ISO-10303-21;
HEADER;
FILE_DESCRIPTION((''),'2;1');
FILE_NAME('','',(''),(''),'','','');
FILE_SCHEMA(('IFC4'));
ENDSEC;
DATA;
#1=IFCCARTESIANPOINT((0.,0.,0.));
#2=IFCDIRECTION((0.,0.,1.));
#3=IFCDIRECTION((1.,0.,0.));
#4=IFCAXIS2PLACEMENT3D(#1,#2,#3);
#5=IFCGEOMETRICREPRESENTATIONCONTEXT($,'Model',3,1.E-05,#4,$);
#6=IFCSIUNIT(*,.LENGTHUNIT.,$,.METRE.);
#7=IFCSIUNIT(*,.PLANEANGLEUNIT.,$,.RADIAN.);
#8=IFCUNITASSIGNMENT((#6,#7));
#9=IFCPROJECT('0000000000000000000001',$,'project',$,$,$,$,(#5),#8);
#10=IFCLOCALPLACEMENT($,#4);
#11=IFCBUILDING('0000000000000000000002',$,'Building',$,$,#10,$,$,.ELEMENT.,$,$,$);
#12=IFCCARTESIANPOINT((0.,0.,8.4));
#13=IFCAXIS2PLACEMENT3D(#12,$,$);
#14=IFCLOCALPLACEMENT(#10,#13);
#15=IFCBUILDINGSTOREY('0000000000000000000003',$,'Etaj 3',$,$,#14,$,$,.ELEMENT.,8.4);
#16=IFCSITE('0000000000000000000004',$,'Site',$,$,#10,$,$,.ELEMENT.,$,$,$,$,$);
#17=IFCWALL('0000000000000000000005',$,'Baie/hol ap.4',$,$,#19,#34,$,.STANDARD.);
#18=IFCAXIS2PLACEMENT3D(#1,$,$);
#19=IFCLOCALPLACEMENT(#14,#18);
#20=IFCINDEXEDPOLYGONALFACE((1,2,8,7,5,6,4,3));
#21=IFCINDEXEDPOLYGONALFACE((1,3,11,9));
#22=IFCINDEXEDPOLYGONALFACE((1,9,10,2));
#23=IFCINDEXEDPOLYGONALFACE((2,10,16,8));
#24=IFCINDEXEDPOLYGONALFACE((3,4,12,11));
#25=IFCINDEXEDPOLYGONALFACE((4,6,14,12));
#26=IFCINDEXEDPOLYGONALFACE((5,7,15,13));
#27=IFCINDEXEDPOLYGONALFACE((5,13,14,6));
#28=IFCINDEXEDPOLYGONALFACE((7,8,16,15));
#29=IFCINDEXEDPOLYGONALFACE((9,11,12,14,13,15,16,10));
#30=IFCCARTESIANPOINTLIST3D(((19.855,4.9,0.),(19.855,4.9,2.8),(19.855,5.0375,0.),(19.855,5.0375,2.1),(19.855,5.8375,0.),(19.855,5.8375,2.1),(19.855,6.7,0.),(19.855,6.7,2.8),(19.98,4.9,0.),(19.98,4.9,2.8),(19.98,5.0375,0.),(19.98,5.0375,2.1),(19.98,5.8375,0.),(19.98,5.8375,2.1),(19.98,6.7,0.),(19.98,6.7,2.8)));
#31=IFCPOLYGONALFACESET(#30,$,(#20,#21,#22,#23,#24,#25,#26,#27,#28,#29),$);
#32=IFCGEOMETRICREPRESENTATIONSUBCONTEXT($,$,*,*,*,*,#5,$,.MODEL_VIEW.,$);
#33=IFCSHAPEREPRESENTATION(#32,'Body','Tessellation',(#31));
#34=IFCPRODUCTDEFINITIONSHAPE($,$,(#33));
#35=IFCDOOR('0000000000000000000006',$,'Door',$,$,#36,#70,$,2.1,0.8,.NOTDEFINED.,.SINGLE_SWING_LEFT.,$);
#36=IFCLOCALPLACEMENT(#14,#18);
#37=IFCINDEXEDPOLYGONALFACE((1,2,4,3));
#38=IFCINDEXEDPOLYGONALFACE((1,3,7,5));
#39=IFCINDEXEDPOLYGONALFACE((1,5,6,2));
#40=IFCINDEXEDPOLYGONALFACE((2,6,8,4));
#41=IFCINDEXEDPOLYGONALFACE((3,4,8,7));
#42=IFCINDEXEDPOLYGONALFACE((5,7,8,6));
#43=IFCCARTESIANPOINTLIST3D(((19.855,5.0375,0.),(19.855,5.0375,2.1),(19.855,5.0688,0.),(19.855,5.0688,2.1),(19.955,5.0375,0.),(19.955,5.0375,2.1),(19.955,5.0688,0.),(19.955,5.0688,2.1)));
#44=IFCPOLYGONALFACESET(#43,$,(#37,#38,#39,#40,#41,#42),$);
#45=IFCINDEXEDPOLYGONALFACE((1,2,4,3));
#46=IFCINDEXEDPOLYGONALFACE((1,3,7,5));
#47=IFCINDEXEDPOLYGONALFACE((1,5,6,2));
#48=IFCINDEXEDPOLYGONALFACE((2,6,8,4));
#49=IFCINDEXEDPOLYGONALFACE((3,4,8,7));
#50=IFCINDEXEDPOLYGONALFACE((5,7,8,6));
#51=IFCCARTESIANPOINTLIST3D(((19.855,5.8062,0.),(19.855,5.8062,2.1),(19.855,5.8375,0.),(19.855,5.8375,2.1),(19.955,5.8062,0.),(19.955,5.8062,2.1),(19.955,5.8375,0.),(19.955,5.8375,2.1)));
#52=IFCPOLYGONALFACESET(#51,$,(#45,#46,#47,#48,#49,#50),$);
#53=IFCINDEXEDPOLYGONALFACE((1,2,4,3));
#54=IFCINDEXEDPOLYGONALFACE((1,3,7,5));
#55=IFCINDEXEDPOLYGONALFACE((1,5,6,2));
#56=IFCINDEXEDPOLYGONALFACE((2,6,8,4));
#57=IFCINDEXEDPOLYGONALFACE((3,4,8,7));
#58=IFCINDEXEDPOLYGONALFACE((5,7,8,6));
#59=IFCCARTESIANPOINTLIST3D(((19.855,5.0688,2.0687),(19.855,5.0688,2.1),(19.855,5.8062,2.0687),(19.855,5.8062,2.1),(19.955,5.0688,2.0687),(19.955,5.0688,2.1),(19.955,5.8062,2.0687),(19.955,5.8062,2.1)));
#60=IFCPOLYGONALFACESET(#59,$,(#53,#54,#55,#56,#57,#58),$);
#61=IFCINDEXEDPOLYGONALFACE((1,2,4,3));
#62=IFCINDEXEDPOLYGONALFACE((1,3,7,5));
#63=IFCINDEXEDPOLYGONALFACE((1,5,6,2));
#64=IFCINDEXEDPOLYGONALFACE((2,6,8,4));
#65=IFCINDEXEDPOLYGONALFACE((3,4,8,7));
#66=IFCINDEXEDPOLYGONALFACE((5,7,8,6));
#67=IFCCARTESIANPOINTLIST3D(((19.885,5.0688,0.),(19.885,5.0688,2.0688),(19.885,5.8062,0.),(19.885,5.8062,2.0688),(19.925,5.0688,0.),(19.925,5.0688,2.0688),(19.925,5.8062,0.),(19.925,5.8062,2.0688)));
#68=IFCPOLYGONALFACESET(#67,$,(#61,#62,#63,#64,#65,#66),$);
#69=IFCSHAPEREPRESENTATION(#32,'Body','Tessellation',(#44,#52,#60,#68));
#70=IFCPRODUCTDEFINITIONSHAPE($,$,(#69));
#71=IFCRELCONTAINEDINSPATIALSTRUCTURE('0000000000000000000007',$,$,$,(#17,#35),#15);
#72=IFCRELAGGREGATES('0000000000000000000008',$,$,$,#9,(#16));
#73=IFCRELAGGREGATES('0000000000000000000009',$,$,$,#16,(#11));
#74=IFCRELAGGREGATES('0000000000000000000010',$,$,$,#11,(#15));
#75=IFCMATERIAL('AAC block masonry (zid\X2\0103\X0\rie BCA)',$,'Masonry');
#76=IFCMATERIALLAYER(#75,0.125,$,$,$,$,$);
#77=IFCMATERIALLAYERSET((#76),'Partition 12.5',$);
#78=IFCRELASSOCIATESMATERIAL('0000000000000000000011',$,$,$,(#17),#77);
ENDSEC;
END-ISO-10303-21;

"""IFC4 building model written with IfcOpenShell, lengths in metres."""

from ifc_helpers import new_model, si_unit, frame, frame_2d, origin, origin_with_axes, origin_2d, place, context, subcontext, project, spatial, rectangle, extrude, material, layer, layer_set, layer_usage, element, fill, save


model = new_model("IFC4")

# Units and contexts
model_context = context("Model", 3, precision=1e-05, world=origin_with_axes())
sub_context = subcontext(model_context, None, None, "MODEL_VIEW")
ifc_project = project(units=[si_unit("LENGTHUNIT", "METRE"), si_unit("PLANEANGLEUNIT", "RADIAN")], contexts=[model_context])

# Site, building, storey
placement = place(None, origin_with_axes())
site = spatial("IfcSite", under=ifc_project, at=placement, Name="Site", CompositionType="ELEMENT")
building = spatial("IfcBuilding", under=site, at=placement, Name="Building", CompositionType="ELEMENT")
storey_placement = place(placement, frame((0.0, 0.0, 8.4)))
storey = spatial("IfcBuildingStorey", under=building, at=storey_placement, Name="Etaj 3", CompositionType="ELEMENT", Elevation=8.4)

# Shared definitions
ifc_material_1 = material(Name="AAC block masonry (zidărie BCA)", Category="Masonry")
ifc_layer_1 = layer(ifc_material_1, 0.125)
ifc_layer_set_1 = layer_set([ifc_layer_1], Name="Partition 12.5")
ifc_layer_usage_1 = layer_usage(ifc_layer_set_1, "AXIS2", "POSITIVE", -0.0625)

# Wall, opening, door
wall_1_placement = place(storey_placement, frame((19.9175, 4.9, 0.0), x_axis=(0.0, 1.0, 0.0)))
wall_1 = element("IfcWall", 1, at=wall_1_placement, inside=storey, material=ifc_layer_usage_1, Name="Baie/hol ap.4", PredefinedType="STANDARD", context=sub_context, shape_type="SweptSolid", body=[
    extrude(rectangle(XDim=1.8, YDim=0.125, at=frame_2d((0.9, 0.0))), origin(), (0.0, 0.0, 1.0), 2.8),
])
opening_1_placement = place(wall_1_placement, frame((0.5375, 0.1125, 0.0), z_axis=(0.0, -1.0, 0.0), x_axis=(1.0, 0.0, 0.0)))
opening_1 = element("IfcOpeningElement", 2, at=opening_1_placement, cuts=wall_1, PredefinedType="OPENING", context=sub_context, shape_type="SweptSolid", body=[
    extrude(rectangle(XDim=0.8, YDim=2.1, at=frame_2d((0.0, 1.05))), origin(), (0.0, 0.0, 1.0), 0.225),
])
door_1_placement = place(wall_1_placement, frame((0.5375, 0.0625, 0.0), z_axis=(0.0, -1.0, 0.0), x_axis=(1.0, 0.0, 0.0)))
door_1 = element("IfcDoor", 3, at=door_1_placement, inside=storey, Name="Door", OperationType="SINGLE_SWING_LEFT", OverallHeight=2.1, OverallWidth=0.8, PredefinedType="NOTDEFINED", context=sub_context, shape_type="SweptSolid", body=[
    extrude(rectangle(XDim=0.0312, YDim=2.1, at=origin_2d()), frame((-0.3844, 1.05, 0.0)), (0.0, 0.0, 1.0), 0.1),
    extrude(rectangle(XDim=0.0312, YDim=2.1, at=origin_2d()), frame((0.3844, 1.05, 0.0)), (0.0, 0.0, 1.0), 0.1),
    extrude(rectangle(XDim=0.7375, YDim=0.0312, at=origin_2d()), frame((0.0, 2.0844, 0.0)), (0.0, 0.0, 1.0), 0.1),
    extrude(rectangle(XDim=0.7375, YDim=2.0688, at=origin_2d()), frame((0.0, 1.0344, 0.03)), (0.0, 0.0, 1.0), 0.04),
])
fill(opening_1, door_1)

save(model, "model.ifc")
